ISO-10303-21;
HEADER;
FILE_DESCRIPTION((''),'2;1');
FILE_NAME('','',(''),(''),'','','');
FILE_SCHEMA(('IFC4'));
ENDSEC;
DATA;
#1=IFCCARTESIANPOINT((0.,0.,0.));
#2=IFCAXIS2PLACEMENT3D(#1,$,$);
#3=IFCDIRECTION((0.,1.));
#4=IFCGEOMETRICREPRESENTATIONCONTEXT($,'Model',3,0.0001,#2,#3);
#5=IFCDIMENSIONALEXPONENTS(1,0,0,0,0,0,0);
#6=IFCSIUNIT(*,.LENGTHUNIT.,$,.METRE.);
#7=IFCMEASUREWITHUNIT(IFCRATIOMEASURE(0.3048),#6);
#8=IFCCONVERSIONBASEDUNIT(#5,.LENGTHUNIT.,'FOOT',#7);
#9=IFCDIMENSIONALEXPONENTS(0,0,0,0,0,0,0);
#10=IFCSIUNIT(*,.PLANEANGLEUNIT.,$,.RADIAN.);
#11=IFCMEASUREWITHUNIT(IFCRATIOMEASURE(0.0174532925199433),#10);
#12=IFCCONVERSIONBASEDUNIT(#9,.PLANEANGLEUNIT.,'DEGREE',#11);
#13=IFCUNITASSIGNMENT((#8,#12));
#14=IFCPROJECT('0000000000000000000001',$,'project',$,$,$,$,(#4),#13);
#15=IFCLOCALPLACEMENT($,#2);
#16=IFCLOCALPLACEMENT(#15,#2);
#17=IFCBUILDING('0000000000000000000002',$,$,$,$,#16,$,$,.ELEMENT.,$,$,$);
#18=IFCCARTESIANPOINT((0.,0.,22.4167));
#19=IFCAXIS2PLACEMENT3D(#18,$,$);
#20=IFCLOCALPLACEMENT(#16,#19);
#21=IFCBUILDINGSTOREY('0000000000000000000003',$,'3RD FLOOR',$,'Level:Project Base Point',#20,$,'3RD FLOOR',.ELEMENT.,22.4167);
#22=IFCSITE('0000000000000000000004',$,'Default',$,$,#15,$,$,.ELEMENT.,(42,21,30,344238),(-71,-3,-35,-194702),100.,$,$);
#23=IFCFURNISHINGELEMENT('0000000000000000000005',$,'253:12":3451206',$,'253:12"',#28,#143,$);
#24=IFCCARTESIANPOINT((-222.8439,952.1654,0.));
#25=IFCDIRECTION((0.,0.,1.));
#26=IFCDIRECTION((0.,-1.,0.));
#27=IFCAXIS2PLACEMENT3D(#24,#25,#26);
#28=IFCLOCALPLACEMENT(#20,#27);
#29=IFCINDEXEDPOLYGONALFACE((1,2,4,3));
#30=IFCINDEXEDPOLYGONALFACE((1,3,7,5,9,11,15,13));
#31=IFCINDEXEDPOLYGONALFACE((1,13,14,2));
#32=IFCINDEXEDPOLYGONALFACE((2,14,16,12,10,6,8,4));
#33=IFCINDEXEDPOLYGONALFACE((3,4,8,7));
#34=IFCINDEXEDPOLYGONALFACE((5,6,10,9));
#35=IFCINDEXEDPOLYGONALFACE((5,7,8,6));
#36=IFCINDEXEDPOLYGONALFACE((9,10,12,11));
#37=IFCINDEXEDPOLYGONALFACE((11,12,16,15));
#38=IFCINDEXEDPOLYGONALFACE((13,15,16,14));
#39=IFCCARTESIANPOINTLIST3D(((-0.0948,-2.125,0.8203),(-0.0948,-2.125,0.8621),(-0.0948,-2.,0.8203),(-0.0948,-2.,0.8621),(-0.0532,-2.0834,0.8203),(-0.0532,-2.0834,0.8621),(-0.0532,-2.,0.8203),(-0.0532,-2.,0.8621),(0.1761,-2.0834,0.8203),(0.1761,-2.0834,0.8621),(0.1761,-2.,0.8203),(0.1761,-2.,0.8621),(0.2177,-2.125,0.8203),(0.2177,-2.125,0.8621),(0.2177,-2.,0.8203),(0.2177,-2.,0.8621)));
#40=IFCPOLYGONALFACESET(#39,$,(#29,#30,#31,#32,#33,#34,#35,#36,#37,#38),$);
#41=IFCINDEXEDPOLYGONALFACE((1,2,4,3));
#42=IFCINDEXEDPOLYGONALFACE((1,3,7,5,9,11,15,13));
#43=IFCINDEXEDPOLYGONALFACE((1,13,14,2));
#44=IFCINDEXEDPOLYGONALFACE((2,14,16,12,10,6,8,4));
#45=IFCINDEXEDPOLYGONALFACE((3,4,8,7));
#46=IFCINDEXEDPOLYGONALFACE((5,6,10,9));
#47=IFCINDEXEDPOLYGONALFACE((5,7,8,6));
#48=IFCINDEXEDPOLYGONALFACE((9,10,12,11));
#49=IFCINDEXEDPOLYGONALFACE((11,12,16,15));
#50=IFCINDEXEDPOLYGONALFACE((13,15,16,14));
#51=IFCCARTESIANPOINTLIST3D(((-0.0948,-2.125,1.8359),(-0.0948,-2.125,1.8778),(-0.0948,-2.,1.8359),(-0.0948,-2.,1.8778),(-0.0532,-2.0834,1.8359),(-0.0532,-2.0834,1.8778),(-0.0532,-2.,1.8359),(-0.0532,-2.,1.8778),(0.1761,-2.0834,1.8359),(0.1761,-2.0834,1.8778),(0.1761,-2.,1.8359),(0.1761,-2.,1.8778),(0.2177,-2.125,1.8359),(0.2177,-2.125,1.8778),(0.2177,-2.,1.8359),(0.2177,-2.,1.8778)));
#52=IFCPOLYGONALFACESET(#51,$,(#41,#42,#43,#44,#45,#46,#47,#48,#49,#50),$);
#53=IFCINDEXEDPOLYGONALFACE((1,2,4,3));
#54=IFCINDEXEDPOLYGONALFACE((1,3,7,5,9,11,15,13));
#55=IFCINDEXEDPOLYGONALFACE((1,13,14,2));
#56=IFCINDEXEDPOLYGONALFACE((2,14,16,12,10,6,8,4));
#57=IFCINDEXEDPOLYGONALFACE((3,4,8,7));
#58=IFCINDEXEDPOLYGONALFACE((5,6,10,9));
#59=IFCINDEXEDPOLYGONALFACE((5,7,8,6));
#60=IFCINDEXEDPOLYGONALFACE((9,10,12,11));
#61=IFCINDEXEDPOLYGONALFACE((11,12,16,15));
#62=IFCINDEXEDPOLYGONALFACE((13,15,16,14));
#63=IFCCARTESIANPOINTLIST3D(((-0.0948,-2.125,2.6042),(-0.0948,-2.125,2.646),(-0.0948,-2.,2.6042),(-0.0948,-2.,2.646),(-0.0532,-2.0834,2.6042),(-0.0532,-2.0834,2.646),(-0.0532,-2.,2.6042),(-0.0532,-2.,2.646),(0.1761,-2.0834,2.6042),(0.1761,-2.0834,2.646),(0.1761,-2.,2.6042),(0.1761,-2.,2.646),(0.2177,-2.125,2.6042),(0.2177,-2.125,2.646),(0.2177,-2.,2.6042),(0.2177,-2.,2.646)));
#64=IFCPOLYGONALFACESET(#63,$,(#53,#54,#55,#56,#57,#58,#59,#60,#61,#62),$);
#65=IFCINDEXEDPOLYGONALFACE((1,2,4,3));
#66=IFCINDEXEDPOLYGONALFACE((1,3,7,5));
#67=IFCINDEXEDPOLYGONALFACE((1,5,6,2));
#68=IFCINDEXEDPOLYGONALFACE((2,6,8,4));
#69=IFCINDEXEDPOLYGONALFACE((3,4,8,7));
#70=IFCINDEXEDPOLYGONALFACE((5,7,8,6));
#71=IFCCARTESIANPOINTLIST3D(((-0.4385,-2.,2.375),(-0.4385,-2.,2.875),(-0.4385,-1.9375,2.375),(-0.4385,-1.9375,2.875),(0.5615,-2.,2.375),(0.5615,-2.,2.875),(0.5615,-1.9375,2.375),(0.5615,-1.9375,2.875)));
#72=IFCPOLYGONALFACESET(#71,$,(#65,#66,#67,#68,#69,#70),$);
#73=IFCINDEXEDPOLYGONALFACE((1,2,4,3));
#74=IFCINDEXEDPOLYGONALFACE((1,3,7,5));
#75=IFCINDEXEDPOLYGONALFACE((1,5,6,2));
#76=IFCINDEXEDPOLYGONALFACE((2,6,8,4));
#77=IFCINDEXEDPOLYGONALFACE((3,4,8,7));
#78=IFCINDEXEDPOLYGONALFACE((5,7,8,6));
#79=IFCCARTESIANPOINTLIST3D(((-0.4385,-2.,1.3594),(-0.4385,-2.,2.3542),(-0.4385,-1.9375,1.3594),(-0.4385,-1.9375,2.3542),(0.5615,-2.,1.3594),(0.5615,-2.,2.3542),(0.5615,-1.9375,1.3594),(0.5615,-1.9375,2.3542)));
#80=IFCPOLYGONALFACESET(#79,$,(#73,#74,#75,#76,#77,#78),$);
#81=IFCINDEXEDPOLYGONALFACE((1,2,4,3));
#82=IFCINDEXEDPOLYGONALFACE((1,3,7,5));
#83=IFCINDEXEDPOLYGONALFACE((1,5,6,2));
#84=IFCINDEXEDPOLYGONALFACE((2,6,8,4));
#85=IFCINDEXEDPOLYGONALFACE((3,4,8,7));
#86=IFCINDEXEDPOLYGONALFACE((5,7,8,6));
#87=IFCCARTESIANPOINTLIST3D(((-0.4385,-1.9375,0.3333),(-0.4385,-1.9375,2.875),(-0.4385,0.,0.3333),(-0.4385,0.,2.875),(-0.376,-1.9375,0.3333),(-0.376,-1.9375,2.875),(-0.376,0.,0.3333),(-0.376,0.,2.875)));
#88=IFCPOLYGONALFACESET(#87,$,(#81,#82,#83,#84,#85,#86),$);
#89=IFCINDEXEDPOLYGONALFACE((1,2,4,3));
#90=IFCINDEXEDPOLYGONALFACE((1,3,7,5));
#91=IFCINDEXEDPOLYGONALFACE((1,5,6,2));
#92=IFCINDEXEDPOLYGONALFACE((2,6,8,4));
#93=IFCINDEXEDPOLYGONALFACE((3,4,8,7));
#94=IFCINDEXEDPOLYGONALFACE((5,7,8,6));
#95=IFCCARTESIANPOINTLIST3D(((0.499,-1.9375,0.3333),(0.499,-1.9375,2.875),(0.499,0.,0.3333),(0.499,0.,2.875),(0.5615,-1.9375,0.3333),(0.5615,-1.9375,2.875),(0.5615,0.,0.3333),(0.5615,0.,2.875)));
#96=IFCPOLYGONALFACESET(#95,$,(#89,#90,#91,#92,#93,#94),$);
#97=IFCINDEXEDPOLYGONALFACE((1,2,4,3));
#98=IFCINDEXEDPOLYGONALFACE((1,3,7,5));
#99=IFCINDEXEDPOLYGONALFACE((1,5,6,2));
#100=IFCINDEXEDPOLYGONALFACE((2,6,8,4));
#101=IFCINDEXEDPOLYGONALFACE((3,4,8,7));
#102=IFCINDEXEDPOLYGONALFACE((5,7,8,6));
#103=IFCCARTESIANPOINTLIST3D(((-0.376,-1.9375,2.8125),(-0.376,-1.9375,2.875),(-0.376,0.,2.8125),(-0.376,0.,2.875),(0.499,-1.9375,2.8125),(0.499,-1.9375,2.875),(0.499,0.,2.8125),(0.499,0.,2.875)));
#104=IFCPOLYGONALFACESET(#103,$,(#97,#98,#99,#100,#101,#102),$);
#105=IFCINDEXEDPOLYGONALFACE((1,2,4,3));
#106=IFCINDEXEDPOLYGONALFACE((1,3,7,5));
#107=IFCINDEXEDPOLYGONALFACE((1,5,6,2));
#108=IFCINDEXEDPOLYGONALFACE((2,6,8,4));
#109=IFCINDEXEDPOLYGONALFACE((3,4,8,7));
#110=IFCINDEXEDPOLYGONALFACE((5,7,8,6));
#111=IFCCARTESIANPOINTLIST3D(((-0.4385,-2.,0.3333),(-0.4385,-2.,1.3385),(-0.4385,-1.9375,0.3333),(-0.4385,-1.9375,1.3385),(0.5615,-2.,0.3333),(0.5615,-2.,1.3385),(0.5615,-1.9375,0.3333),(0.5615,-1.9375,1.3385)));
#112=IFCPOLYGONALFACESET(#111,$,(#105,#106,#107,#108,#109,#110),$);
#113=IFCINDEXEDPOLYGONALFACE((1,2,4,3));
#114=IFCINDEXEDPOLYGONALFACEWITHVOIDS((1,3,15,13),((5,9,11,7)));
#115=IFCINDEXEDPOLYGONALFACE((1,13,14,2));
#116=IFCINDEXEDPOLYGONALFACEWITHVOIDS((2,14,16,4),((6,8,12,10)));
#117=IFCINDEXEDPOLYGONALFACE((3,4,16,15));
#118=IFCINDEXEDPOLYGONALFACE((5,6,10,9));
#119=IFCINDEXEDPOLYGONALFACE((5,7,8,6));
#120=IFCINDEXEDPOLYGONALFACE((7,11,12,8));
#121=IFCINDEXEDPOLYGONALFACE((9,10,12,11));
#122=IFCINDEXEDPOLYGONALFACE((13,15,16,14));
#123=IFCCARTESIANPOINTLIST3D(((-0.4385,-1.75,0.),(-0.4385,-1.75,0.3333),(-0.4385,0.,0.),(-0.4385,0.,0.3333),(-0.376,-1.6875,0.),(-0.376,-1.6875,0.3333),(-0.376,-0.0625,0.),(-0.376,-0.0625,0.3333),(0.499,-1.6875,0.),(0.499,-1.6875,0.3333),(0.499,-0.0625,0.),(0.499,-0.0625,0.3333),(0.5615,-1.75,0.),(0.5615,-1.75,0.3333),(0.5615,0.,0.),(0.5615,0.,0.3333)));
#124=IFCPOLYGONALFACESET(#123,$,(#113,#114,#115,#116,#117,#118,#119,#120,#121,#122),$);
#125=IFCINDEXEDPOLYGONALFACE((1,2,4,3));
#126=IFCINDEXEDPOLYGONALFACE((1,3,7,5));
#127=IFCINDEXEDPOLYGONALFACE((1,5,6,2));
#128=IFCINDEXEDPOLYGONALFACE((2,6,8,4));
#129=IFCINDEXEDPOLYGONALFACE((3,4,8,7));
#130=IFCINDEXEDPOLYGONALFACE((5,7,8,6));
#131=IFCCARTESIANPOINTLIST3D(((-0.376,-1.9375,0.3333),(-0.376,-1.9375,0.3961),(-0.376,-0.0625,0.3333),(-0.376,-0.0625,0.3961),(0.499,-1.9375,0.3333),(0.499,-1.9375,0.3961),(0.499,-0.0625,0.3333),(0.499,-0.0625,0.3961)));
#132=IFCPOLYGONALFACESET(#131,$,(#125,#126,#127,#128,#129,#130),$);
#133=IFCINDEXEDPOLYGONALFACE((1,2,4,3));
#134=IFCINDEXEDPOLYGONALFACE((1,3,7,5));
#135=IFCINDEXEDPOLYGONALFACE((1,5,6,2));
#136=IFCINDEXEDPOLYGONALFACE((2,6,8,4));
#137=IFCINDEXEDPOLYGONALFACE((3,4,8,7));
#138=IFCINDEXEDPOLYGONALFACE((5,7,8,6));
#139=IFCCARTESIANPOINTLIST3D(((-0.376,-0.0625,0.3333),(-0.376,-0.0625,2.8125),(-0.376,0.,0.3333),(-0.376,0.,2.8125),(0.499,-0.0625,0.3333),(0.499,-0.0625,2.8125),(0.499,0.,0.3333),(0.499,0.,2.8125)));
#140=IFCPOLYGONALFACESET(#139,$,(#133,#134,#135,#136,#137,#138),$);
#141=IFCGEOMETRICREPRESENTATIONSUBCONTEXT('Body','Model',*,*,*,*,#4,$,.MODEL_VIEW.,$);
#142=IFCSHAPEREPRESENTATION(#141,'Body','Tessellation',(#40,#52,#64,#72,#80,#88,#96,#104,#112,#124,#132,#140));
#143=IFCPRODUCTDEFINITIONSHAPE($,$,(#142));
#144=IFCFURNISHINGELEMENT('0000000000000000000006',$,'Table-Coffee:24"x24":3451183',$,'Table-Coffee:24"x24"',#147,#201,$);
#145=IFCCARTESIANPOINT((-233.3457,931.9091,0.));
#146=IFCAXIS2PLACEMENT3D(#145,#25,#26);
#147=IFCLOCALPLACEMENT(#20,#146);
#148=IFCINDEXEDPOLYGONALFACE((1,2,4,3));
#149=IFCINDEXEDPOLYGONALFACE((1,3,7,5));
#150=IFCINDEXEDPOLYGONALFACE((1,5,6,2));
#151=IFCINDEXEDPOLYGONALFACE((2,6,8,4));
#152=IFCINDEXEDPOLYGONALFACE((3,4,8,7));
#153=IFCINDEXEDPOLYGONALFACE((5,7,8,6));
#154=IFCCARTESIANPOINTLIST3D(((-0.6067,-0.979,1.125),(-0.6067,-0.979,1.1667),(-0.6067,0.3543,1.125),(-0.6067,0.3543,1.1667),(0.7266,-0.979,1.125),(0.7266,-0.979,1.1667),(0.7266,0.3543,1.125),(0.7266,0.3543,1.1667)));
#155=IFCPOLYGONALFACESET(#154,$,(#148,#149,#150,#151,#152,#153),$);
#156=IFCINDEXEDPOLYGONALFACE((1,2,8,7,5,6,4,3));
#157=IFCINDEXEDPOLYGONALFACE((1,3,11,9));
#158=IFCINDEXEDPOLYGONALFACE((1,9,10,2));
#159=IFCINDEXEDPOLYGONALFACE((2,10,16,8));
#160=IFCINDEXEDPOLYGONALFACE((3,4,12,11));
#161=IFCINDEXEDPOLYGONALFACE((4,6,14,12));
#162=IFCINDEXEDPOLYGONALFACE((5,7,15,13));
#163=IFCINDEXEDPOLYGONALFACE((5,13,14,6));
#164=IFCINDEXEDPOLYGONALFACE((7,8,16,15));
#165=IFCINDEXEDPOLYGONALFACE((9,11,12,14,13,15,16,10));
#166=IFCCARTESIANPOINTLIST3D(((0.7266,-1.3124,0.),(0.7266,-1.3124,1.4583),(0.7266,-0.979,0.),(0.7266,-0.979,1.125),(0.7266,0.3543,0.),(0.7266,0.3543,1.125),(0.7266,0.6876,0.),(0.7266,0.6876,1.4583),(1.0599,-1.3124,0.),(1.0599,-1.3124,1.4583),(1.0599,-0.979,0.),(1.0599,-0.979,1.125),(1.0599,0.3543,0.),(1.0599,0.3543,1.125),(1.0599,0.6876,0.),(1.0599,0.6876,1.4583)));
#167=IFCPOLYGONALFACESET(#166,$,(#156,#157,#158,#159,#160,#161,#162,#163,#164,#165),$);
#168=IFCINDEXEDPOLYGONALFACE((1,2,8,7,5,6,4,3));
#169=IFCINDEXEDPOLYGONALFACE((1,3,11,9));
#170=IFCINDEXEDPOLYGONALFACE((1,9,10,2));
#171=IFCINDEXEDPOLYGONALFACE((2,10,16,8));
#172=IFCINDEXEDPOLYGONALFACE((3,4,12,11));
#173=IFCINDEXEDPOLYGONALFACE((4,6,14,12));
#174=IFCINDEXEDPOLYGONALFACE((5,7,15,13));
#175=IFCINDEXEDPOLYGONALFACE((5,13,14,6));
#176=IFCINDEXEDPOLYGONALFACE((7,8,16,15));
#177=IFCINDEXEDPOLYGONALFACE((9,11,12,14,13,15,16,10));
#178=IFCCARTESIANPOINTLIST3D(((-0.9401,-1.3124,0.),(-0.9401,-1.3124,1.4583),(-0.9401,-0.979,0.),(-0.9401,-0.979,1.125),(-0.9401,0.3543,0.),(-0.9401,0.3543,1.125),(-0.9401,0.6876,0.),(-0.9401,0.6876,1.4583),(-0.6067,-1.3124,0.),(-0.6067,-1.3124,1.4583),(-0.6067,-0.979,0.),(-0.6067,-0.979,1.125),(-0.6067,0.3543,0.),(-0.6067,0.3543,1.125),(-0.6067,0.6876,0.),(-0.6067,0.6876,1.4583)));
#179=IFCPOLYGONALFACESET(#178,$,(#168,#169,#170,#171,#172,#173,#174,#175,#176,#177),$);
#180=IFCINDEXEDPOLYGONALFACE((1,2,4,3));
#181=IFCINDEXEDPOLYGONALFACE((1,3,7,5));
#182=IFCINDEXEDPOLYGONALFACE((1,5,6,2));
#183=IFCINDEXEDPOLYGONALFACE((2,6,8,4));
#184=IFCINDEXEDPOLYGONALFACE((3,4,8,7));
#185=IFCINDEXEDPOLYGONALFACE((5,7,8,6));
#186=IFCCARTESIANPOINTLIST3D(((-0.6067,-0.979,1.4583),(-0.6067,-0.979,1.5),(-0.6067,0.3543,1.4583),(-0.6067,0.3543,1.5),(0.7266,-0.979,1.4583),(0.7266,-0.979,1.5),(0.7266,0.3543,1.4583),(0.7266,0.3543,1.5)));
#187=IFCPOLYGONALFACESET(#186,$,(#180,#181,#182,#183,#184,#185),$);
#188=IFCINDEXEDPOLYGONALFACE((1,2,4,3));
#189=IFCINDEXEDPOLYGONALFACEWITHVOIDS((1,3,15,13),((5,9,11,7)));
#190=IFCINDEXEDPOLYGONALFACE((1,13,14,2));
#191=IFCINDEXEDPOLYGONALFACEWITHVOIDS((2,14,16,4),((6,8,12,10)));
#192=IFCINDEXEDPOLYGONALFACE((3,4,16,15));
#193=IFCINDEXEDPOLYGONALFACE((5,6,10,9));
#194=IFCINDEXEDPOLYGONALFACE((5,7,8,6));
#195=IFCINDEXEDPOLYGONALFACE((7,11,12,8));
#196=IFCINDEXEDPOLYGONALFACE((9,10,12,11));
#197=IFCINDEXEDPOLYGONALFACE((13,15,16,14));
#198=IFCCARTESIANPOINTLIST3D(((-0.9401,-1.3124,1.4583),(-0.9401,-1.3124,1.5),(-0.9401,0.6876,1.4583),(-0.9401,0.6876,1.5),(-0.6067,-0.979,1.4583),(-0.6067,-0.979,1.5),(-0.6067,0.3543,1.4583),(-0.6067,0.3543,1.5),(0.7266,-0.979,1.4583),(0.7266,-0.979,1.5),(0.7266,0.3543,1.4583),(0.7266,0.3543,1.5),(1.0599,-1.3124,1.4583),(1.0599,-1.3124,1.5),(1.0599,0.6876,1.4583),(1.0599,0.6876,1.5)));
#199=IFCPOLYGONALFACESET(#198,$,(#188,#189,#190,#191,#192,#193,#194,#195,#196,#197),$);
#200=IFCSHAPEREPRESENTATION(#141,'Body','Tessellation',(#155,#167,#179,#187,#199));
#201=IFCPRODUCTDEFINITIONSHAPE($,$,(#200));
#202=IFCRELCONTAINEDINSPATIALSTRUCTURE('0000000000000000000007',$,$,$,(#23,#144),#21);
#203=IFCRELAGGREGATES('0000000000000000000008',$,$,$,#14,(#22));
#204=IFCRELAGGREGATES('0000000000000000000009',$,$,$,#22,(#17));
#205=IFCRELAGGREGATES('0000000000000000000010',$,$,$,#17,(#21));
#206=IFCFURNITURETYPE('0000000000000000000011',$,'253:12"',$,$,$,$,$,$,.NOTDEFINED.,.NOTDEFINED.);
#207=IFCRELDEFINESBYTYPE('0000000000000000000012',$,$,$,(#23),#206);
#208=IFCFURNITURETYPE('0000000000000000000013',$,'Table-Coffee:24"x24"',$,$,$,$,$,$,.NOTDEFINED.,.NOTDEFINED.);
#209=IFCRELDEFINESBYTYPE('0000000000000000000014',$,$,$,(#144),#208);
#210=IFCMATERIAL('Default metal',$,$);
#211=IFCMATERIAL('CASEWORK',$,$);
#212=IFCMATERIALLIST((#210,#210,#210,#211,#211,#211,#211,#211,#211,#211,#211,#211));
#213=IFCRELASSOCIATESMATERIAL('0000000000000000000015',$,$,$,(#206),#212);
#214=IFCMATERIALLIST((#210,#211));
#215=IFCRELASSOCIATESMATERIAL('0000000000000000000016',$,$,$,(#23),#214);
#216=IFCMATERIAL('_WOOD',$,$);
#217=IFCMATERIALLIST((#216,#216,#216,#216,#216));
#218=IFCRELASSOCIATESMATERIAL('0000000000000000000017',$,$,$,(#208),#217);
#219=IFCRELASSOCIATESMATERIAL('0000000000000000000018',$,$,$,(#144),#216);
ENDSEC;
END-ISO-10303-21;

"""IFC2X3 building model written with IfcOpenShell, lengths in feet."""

from ifc_helpers import new_model, entity, si_unit, converted_unit, direction, frame, frame_2d, origin, origin_2d_with_axis, place, context, subcontext, project, spatial, polyline, rectangle, outline, extrude, source, transform, mapped, material, material_list, type_object, type_shapes, element, save


model = new_model("IFC2X3")

# Units and contexts
model_context = context("Model", 3, precision=0.0001, world=origin(), true_north=direction((0.0, 1.0)))
body_context = subcontext(model_context, "Body", "Model", "MODEL_VIEW")
ifc_project = project(units=[converted_unit("LENGTHUNIT", "FOOT", entity("IfcRatioMeasure", 0.3048), si_unit("LENGTHUNIT", "METRE"), dimensions=[1, 0, 0, 0, 0, 0, 0]), converted_unit("PLANEANGLEUNIT", "DEGREE", entity("IfcRatioMeasure", 0.0174532925199433), si_unit("PLANEANGLEUNIT", "RADIAN"), dimensions=[0, 0, 0, 0, 0, 0, 0])], contexts=[model_context])

# Site, building, storey
site_placement = place(None, origin())
site = spatial("IfcSite", under=ifc_project, at=site_placement, Name="Default", CompositionType="ELEMENT", RefLatitude=(42, 21, 30, 344238), RefLongitude=(-71, -3, -35, -194702), RefElevation=100.0)
building_placement = place(site_placement, origin())
building = spatial("IfcBuilding", under=site, at=building_placement, CompositionType="ELEMENT")
storey_placement = place(building_placement, frame((0.0, 0.0, 22.4167)))
storey = spatial("IfcBuildingStorey", under=building, at=storey_placement, Name="3RD FLOOR", ObjectType="Level:Project Base Point", LongName="3RD FLOOR", CompositionType="ELEMENT", Elevation=22.4167)

# Furnishing elements
ifc_material_1 = material(Name="Default metal")
ifc_material_2 = material(Name="CASEWORK")
ifc_material_list_1 = material_list([ifc_material_1, ifc_material_1, ifc_material_1, ifc_material_2, ifc_material_2, ifc_material_2, ifc_material_2, ifc_material_2, ifc_material_2, ifc_material_2, ifc_material_2, ifc_material_2])
furniture_type_1 = type_object("IfcFurnitureType", Name="253:12\"", material=ifc_material_list_1)
shared_shape_1 = source(origin(), body_context, "Body", "SweptSolid", [
    extrude(outline(polyline([(-0.0521, -0.1562), (0.0729, -0.1562), (0.0729, 0.1562), (-0.0521, 0.1562), (-0.0521, 0.1146), (0.0313, 0.1146), (0.0313, -0.1146), (-0.0521, -0.1146), (-0.0521, -0.1562)])), frame((0.0615, -2.0521, 0.8203), z_axis=(0.0, 0.0, 1.0), x_axis=(0.0, -1.0, 0.0)), (0.0, 0.0, 1.0), 0.0418),
    extrude(outline(polyline([(-0.0521, -0.1562), (0.0729, -0.1562), (0.0729, 0.1562), (-0.0521, 0.1562), (-0.0521, 0.1146), (0.0313, 0.1146), (0.0313, -0.1146), (-0.0521, -0.1146), (-0.0521, -0.1562)])), frame((0.0615, -2.0521, 1.8359), z_axis=(0.0, 0.0, 1.0), x_axis=(0.0, -1.0, 0.0)), (0.0, 0.0, 1.0), 0.0418),
    extrude(outline(polyline([(-0.0521, -0.1562), (0.0729, -0.1562), (0.0729, 0.1562), (-0.0521, 0.1562), (-0.0521, 0.1146), (0.0313, 0.1146), (0.0313, -0.1146), (-0.0521, -0.1146), (-0.0521, -0.1562)])), frame((0.0615, -2.0521, 2.6042), z_axis=(0.0, 0.0, 1.0), x_axis=(0.0, -1.0, 0.0)), (0.0, 0.0, 1.0), 0.0418),
    extrude(rectangle(XDim=0.0625, YDim=1.0, at=origin_2d_with_axis()), frame((0.0615, -1.9688, 2.375), z_axis=(0.0, 0.0, 1.0), x_axis=(0.0, 1.0, 0.0)), (0.0, 0.0, 1.0), 0.5),
    extrude(rectangle(XDim=0.0625, YDim=1.0, at=origin_2d_with_axis()), frame((0.0615, -1.9688, 1.3594), z_axis=(0.0, 0.0, 1.0), x_axis=(0.0, 1.0, 0.0)), (0.0, 0.0, 1.0), 0.9948),
    extrude(rectangle(XDim=0.0625, YDim=1.9375, at=frame_2d((0.0, 0.0), x_axis=(1.0, 0.0))), frame((-0.4073, -0.9687, 0.3333)), (0.0, 0.0, 1.0), 2.5417),
    extrude(rectangle(XDim=0.0625, YDim=1.9375, at=frame_2d((0.0, 0.0), x_axis=(1.0, 0.0))), frame((0.5302, -0.9687, 0.3333)), (0.0, 0.0, 1.0), 2.5417),
    extrude(rectangle(XDim=0.875, YDim=1.9375, at=origin_2d_with_axis()), frame((0.0615, -0.9688, 2.8125), z_axis=(0.0, 0.0, 1.0), x_axis=(-1.0, 0.0, 0.0)), (0.0, 0.0, 1.0), 0.0625),
    extrude(rectangle(XDim=0.0625, YDim=1.0, at=origin_2d_with_axis()), frame((0.0615, -1.9688, 0.3333), z_axis=(0.0, 0.0, 1.0), x_axis=(0.0, 1.0, 0.0)), (0.0, 0.0, 1.0), 1.0052),
    extrude(outline(polyline([(-0.5, -0.875), (0.5, -0.875), (0.5, 0.875), (-0.5, 0.875), (-0.5, -0.875)]), holes=[polyline([(-0.4375, -0.8125), (-0.4375, 0.8125), (0.4375, 0.8125), (0.4375, -0.8125), (-0.4375, -0.8125)])]), frame((0.0615, -0.875, 0.0)), (0.0, 0.0, 1.0), 0.3333),
    extrude(rectangle(XDim=0.875, YDim=1.875, at=frame_2d((0.0, 0.0), x_axis=(1.0, 0.0))), frame((0.0615, -1.0, 0.3333), z_axis=(0.0, 0.0, 1.0), x_axis=(-1.0, 0.0, 0.0)), (0.0, 0.0, 1.0), 0.0627),
    extrude(rectangle(XDim=0.0625, YDim=0.875, at=origin_2d_with_axis()), frame((0.0615, -0.0312, 0.3333), z_axis=(0.0, 0.0, 1.0), x_axis=(0.0, 1.0, 0.0)), (0.0, 0.0, 1.0), 2.4792),
])
type_shapes(furniture_type_1, [shared_shape_1])
ifc_material_list_2 = material_list([ifc_material_1, ifc_material_2])
furnishing_1_placement = place(storey_placement, frame((-222.8439, 952.1654, 0.0), z_axis=(0.0, 0.0, 1.0), x_axis=(0.0, -1.0, 0.0)))
element("IfcFurnishingElement", 1, at=furnishing_1_placement, inside=storey, type_object=furniture_type_1, material=ifc_material_list_2, Name="253:12\":3451206", ObjectType="253:12\"", context=body_context, shape_type="MappedRepresentation", body=[
    mapped(shared_shape_1, transform((0.0, 0.0, 0.0), scale=1.0)),
])
ifc_material_3 = material(Name="_WOOD")
ifc_material_list_3 = material_list([ifc_material_3, ifc_material_3, ifc_material_3, ifc_material_3, ifc_material_3])
furniture_type_2 = type_object("IfcFurnitureType", Name="Table-Coffee:24\"x24\"", material=ifc_material_list_3)
shared_shape_2 = source(origin(), body_context, "Body", "SweptSolid", [
    extrude(rectangle(XDim=1.3333, YDim=1.3333, at=origin_2d_with_axis()), frame((0.0599, -0.3124, 1.125), z_axis=(0.0, 0.0, 1.0), x_axis=(0.0, 1.0, 0.0)), (0.0, 0.0, 1.0), 0.0417),
    extrude(outline(polyline([(-1.0, -0.6458), (-0.6667, -0.6458), (-0.6667, 0.4792), (0.6667, 0.4792), (0.6667, -0.6458), (1.0, -0.6458), (1.0, 0.8125), (-1.0, 0.8125), (-1.0, -0.6458)])), frame((0.7266, -0.3124, 0.6458), z_axis=(1.0, 0.0, 0.0), x_axis=(0.0, 1.0, 0.0)), (0.0, 0.0, 1.0), 0.3333),
    extrude(outline(polyline([(-0.8125, -1.0), (0.6458, -1.0), (0.6458, -0.6667), (-0.4792, -0.6667), (-0.4792, 0.6667), (0.6458, 0.6667), (0.6458, 1.0), (-0.8125, 1.0), (-0.8125, -1.0)])), frame((-0.9401, -0.3124, 0.6458), z_axis=(1.0, 0.0, 0.0), x_axis=(0.0, 0.0, -1.0)), (0.0, 0.0, 1.0), 0.3333),
    extrude(rectangle(XDim=1.3333, YDim=1.3333, at=origin_2d_with_axis()), frame((0.0599, -0.3124, 1.4583), z_axis=(0.0, 0.0, 1.0), x_axis=(0.0, 1.0, 0.0)), (0.0, 0.0, 1.0), 0.0417),
    extrude(outline(polyline([(-1.0, -1.0), (1.0, -1.0), (1.0, 1.0), (-1.0, 1.0), (-1.0, -1.0)]), holes=[polyline([(-0.6667, -0.6667), (-0.6667, 0.6667), (0.6667, 0.6667), (0.6667, -0.6667), (-0.6667, -0.6667)])]), frame((0.0599, -0.3124, 1.4583), z_axis=(0.0, 0.0, 1.0), x_axis=(0.0, 1.0, 0.0)), (0.0, 0.0, 1.0), 0.0417),
])
type_shapes(furniture_type_2, [shared_shape_2])
furnishing_2_placement = place(storey_placement, frame((-233.3457, 931.9091, 0.0), z_axis=(0.0, 0.0, 1.0), x_axis=(0.0, -1.0, 0.0)))
element("IfcFurnishingElement", 2, at=furnishing_2_placement, inside=storey, type_object=furniture_type_2, material=ifc_material_3, Name="Table-Coffee:24\"x24\":3451183", ObjectType="Table-Coffee:24\"x24\"", context=body_context, shape_type="MappedRepresentation", body=[
    mapped(shared_shape_2, transform((0.0, 0.0, 0.0), scale=1.0)),
])

save(model, "model.ifc")
